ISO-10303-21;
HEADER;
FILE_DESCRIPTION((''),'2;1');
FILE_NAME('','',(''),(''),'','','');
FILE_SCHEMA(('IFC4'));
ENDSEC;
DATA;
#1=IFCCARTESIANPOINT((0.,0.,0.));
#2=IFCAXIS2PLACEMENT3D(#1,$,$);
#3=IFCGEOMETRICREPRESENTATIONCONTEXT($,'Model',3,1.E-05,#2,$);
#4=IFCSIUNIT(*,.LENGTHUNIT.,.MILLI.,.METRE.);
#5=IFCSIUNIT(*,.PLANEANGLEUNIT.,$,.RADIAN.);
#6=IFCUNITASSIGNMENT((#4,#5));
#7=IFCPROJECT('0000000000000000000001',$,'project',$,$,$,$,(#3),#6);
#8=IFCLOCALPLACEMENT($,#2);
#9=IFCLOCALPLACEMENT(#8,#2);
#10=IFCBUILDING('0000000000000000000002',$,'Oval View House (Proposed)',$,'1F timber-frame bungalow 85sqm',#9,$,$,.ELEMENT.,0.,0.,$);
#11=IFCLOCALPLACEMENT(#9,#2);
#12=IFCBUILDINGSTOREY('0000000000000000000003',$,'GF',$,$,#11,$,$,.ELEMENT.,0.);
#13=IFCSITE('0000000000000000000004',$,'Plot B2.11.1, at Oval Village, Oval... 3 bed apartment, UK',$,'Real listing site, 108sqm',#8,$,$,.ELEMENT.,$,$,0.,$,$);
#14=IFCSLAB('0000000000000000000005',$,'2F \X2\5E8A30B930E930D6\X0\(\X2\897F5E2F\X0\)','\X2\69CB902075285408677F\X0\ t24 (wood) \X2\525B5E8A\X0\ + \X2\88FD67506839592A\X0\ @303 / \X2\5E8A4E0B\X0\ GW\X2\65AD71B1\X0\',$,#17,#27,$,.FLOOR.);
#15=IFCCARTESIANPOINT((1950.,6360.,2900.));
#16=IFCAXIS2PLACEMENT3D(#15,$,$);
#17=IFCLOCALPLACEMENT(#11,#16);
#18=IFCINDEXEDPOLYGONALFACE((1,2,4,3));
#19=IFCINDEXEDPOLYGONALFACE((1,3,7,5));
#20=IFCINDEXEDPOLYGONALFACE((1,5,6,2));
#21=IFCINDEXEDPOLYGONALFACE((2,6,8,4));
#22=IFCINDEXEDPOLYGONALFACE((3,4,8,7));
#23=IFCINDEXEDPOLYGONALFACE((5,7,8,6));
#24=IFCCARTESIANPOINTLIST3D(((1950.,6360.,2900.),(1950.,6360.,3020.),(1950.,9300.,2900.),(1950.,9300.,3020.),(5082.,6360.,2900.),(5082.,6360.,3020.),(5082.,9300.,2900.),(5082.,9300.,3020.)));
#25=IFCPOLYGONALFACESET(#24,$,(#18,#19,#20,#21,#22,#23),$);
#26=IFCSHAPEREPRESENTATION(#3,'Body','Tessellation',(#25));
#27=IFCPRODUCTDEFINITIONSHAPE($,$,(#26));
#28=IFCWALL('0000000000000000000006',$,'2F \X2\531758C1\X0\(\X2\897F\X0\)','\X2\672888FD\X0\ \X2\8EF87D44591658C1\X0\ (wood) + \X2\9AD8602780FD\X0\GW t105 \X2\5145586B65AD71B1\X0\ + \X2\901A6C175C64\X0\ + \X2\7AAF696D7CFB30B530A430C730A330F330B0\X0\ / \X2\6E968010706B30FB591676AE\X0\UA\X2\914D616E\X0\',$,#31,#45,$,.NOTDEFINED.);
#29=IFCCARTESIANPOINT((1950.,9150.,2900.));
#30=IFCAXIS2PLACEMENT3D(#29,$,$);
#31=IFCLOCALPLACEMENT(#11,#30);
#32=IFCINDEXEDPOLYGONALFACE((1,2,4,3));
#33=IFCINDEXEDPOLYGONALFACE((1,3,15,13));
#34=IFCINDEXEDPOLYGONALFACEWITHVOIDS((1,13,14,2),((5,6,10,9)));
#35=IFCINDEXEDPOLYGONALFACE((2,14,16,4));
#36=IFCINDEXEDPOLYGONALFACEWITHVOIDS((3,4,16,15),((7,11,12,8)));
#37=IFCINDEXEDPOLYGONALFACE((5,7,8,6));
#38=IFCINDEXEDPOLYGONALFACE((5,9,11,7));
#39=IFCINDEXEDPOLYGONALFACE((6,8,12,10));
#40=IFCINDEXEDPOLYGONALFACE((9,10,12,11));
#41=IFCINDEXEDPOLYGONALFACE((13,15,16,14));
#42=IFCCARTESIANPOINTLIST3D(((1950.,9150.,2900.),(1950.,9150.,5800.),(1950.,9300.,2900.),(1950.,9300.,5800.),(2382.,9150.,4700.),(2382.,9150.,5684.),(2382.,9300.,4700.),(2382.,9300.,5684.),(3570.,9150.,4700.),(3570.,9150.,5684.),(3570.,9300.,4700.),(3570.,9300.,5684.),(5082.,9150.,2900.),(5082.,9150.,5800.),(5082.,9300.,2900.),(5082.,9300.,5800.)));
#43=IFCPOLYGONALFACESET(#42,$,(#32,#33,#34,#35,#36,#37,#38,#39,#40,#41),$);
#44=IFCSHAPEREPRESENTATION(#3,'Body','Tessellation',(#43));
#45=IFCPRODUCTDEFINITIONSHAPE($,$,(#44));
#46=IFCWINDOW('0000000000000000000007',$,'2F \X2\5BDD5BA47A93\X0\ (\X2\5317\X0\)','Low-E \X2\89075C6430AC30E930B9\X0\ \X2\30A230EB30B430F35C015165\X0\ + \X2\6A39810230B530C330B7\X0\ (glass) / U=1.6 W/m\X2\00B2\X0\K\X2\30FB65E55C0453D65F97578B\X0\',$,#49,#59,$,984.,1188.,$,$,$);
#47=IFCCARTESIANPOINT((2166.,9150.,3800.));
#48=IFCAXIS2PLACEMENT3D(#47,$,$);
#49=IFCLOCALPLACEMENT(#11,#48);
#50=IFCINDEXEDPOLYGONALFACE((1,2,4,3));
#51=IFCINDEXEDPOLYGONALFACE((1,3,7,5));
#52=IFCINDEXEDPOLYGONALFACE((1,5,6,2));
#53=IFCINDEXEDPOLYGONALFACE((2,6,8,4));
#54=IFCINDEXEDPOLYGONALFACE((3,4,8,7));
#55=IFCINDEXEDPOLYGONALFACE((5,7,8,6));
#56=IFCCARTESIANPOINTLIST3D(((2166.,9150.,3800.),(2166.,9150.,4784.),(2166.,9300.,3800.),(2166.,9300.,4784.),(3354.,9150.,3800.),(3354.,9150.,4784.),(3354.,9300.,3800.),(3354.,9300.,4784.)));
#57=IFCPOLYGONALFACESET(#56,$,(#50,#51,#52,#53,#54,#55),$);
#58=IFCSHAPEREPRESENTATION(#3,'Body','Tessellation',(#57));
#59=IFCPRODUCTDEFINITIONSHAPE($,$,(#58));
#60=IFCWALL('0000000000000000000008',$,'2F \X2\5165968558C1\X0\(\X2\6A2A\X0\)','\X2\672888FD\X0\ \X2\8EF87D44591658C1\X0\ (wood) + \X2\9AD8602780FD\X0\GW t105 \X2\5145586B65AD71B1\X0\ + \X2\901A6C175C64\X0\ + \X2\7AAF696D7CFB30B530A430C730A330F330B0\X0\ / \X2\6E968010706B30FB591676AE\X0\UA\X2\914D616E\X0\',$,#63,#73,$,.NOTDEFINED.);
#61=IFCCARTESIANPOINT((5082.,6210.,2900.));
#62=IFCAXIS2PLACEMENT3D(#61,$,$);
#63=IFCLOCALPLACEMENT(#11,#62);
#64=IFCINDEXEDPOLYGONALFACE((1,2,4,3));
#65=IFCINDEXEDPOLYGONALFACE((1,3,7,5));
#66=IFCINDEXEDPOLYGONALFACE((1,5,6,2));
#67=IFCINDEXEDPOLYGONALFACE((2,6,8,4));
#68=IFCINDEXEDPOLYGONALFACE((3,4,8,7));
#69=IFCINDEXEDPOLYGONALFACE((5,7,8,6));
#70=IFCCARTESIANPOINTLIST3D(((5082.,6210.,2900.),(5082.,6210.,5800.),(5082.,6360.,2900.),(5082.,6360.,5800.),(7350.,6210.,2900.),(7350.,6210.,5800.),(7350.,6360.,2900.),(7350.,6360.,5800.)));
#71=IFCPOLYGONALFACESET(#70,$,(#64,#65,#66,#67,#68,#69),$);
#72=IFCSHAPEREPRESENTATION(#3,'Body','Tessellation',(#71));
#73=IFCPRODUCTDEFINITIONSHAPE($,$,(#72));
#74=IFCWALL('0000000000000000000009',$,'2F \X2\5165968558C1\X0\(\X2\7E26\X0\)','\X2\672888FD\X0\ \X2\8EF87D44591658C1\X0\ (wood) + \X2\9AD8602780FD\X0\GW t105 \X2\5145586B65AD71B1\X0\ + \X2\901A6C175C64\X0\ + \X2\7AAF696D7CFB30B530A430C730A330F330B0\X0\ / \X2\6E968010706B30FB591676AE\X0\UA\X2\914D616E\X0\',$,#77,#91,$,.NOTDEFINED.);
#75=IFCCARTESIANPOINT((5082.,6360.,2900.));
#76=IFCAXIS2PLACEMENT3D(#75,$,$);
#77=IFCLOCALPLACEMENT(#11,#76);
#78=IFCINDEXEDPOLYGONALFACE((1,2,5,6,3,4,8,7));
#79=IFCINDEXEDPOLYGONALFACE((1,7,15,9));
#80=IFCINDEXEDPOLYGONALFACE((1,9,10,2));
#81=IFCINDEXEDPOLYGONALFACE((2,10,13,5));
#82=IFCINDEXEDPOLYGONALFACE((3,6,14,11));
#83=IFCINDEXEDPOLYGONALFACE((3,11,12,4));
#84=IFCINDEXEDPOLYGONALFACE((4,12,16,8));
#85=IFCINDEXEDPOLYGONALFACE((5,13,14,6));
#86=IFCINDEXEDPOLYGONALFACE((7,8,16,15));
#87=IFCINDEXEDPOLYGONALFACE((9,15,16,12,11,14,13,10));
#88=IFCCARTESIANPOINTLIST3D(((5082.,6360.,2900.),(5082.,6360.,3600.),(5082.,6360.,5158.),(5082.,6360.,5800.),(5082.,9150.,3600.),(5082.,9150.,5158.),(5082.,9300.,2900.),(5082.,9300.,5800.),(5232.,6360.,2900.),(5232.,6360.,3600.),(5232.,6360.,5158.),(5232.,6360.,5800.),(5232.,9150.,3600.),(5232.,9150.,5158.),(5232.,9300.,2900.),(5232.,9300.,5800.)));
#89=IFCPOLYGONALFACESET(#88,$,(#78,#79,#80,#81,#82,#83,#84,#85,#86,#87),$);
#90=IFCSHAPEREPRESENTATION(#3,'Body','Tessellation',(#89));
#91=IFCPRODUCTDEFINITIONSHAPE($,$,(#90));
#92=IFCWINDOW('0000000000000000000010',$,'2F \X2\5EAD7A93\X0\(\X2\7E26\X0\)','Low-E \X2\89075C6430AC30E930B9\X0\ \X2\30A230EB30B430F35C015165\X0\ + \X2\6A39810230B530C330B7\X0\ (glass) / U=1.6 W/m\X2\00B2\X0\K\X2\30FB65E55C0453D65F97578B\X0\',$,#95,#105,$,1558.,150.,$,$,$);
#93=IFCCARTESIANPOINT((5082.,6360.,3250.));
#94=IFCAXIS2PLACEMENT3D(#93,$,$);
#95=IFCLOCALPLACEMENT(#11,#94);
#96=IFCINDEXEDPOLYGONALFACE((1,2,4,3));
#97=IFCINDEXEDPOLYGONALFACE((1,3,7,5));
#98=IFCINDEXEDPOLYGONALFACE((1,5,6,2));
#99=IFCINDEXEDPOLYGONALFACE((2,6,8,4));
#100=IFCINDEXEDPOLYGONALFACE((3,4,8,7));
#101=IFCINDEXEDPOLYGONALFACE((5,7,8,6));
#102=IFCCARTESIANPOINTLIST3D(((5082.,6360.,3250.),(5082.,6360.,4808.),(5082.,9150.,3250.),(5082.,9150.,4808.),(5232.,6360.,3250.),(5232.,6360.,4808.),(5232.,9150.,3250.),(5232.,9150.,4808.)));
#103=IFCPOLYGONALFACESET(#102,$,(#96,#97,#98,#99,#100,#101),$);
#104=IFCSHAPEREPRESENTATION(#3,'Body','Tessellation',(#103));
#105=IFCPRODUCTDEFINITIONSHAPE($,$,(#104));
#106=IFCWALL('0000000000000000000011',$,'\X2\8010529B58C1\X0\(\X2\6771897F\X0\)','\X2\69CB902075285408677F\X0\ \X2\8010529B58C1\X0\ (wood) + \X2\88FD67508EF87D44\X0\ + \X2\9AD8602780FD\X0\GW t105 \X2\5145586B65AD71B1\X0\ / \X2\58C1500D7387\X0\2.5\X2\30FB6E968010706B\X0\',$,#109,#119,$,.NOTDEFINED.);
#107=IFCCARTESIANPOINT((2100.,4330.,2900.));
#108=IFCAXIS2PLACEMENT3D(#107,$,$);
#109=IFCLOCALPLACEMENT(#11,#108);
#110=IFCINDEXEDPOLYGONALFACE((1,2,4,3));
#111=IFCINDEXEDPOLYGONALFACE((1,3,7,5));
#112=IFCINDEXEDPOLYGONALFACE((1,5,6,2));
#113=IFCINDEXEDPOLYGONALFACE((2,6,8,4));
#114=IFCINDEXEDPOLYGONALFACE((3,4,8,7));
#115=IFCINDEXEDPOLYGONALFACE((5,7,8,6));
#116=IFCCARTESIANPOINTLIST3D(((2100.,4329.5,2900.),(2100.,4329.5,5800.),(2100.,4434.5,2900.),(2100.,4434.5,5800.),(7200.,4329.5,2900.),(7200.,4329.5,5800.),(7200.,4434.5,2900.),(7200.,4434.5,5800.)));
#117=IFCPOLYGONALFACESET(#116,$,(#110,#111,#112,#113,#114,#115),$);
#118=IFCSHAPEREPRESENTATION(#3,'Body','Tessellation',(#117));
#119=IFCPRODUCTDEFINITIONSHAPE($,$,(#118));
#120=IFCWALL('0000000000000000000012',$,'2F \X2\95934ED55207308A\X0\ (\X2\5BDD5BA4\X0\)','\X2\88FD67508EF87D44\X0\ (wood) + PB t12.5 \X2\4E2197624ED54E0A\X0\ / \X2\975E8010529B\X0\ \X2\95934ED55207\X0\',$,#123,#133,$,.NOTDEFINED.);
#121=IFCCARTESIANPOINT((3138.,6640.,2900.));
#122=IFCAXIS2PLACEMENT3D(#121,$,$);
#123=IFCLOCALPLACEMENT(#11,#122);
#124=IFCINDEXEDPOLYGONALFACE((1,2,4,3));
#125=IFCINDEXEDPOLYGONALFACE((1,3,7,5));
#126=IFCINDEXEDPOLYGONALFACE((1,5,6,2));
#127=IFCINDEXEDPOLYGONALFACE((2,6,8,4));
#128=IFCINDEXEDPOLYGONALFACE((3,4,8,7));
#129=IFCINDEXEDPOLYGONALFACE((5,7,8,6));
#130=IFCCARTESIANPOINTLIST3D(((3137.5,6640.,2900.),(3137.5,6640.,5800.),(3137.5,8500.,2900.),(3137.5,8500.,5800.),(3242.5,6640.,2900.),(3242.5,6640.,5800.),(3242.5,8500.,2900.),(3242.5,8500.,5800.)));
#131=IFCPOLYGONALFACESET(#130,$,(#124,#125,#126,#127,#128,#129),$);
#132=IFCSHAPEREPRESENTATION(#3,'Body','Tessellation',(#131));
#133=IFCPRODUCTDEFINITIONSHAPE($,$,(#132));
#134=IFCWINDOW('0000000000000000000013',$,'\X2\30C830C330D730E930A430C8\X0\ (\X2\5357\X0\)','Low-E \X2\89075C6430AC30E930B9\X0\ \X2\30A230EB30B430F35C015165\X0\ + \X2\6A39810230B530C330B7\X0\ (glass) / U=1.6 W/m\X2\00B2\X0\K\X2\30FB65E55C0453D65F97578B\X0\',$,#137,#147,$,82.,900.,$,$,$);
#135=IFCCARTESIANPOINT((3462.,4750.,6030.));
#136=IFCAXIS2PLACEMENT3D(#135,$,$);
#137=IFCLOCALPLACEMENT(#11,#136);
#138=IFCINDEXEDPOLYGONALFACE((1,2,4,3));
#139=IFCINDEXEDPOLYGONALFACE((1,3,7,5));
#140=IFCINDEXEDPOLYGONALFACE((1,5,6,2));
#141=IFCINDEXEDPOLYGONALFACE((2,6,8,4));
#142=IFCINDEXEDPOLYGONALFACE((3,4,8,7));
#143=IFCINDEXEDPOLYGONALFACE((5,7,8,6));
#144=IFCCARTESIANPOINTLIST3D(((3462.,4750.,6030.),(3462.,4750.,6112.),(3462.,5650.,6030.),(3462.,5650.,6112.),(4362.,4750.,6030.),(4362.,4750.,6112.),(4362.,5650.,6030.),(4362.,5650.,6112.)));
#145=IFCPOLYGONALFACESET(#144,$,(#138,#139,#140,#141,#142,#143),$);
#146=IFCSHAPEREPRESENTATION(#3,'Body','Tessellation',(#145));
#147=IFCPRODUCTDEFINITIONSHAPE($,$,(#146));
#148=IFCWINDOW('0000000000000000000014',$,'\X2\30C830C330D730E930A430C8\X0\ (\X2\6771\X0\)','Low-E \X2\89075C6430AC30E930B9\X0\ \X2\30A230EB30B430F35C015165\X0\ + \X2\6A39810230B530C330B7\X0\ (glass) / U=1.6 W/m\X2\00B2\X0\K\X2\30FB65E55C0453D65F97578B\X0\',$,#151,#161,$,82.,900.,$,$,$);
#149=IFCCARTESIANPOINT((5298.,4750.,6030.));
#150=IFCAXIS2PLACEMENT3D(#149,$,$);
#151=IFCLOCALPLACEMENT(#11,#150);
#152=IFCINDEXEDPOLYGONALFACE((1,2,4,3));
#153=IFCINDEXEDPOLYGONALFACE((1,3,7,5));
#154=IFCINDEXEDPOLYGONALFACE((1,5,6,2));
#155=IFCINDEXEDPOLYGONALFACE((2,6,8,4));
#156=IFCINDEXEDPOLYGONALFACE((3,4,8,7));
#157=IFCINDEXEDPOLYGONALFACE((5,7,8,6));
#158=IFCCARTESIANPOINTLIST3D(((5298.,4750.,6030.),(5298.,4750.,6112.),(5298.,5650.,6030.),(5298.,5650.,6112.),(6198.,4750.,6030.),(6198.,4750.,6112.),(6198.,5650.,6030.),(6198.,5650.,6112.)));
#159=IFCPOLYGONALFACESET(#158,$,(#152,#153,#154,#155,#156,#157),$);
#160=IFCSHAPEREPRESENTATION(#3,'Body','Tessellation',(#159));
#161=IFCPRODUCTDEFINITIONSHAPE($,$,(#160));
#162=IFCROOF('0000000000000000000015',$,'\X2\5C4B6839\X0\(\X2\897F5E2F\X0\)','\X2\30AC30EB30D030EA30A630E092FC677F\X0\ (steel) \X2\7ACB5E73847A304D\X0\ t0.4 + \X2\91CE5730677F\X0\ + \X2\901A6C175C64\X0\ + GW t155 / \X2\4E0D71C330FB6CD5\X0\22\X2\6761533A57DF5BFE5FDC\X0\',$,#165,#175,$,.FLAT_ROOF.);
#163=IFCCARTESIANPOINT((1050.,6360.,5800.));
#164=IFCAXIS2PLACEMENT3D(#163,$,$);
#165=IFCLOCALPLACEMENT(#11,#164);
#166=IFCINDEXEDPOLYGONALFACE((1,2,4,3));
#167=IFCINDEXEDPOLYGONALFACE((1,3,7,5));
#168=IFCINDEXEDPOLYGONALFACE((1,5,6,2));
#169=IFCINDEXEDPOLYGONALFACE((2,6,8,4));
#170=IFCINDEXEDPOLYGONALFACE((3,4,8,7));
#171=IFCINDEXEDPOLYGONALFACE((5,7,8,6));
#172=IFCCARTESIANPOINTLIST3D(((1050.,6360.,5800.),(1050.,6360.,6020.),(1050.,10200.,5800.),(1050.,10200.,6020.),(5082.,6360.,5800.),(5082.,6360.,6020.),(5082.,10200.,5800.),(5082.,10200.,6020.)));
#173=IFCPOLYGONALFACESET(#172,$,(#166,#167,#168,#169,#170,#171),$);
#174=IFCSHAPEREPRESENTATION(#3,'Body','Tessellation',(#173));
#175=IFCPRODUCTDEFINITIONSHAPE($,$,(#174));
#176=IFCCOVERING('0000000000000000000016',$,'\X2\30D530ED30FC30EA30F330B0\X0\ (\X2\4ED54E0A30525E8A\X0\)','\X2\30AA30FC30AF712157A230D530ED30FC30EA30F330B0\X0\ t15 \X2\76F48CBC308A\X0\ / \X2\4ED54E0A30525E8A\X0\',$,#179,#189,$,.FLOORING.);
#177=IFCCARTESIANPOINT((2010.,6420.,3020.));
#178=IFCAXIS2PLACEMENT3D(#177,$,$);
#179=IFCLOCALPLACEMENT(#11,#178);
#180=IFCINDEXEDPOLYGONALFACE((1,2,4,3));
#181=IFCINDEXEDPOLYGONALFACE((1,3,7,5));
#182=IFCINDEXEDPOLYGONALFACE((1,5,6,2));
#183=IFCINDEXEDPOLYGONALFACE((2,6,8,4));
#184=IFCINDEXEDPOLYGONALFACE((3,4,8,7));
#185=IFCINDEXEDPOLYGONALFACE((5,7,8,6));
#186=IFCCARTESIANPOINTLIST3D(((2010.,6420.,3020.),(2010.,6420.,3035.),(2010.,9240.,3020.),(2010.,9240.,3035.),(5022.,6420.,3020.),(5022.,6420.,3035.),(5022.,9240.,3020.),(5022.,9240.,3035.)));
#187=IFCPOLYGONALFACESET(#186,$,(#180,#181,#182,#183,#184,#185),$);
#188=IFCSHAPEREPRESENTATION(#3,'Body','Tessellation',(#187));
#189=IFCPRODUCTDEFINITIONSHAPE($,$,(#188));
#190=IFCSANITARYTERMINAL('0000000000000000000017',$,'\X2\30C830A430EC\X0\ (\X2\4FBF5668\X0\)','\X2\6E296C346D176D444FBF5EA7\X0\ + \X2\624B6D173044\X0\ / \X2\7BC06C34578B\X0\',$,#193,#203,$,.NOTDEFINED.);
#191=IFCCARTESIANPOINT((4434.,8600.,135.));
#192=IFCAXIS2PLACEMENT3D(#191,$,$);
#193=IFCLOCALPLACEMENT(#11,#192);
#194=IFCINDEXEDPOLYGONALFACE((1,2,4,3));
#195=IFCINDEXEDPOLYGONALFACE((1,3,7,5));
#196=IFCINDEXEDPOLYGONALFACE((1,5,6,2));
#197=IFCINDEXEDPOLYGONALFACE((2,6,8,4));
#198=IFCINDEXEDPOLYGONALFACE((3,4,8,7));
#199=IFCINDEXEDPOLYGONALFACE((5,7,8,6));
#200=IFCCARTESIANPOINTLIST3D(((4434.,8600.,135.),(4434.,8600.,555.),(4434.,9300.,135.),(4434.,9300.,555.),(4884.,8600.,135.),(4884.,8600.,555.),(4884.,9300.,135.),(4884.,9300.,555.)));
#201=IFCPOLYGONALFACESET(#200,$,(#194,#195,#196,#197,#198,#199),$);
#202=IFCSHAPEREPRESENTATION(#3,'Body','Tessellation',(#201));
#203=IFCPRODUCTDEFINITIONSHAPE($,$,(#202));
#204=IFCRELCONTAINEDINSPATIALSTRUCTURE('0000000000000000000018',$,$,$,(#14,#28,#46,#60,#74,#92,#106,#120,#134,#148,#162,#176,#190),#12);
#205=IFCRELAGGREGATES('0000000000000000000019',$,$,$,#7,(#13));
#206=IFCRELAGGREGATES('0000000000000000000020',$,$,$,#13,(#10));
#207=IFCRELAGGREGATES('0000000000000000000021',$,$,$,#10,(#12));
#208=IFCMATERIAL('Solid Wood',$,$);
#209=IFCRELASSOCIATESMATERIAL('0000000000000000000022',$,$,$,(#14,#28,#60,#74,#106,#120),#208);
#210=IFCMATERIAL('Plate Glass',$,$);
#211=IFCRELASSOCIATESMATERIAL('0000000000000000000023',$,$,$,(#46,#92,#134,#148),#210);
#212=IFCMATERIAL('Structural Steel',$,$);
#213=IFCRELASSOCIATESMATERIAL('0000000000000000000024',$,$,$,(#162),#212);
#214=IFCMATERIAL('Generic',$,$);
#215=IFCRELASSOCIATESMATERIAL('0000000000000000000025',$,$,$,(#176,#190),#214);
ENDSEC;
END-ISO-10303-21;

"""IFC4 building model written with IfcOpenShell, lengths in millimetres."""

from ifc_helpers import new_model, si_unit, frame, frame_2d, origin, place, context, project, spatial, rectangle, extrude, material, element, fill, save


model = new_model("IFC4")

# Units and contexts
model_context = context("Model", 3, precision=1e-05, world=origin())
ifc_project = project(units=[si_unit("LENGTHUNIT", "METRE", prefix="MILLI"), si_unit("PLANEANGLEUNIT", "RADIAN")], contexts=[model_context])

# Site, building, storey
site_placement = place(None, origin())
site = spatial("IfcSite", under=ifc_project, at=site_placement, Name="Plot B2.11.1, at Oval Village, Oval... 3 bed apartment, UK", ObjectType="Real listing site, 108sqm", CompositionType="ELEMENT", RefElevation=0.0)
building_placement = place(site_placement, origin())
building = spatial("IfcBuilding", under=site, at=building_placement, Name="Oval View House (Proposed)", ObjectType="1F timber-frame bungalow 85sqm", CompositionType="ELEMENT", ElevationOfRefHeight=0.0, ElevationOfTerrain=0.0)
storey_placement = place(building_placement, origin())
storey = spatial("IfcBuildingStorey", under=building, at=storey_placement, Name="GF", CompositionType="ELEMENT", Elevation=0.0)

# Slab
ifc_material_1 = material(Name="Solid Wood")
slab_placement = place(storey_placement, frame((1950.0, 6360.0, 2900.0)))
element("IfcSlab", 1, at=slab_placement, inside=storey, material=ifc_material_1, Name="2F 床スラブ(西帯)", Description="構造用合板 t24 (wood) 剛床 + 製材根太 @303 / 床下 GW断熱", PredefinedType="FLOOR", context=model_context, shape_type="SweptSolid", body=[
    extrude(rectangle(XDim=3132.0, YDim=2940.0, at=frame_2d((1566.0, 1470.0))), frame((1950.0, 6360.0, 2900.0)), (0.0, 0.0, 1.0), 120.0),
])

# Wall, opening, window
wall_1_placement = place(storey_placement, frame((1950.0, 9150.0, 2900.0)))
wall_1 = element("IfcWall", 2, at=wall_1_placement, inside=storey, material=ifc_material_1, Name="2F 北壁(西)", Description="木製 軸組外壁 (wood) + 高性能GW t105 充填断熱 + 通気層 + 窯業系サイディング / 準耐火・外皮UA配慮", PredefinedType="NOTDEFINED", context=model_context, shape_type="SweptSolid", body=[
    extrude(rectangle(XDim=3132.0, YDim=150.0, at=frame_2d((1566.0, 75.0))), frame((1950.0, 9150.0, 2900.0)), (0.0, 0.0, 1.0), 2900.0),
])
opening_1_placement = place(storey_placement, frame((2166.0, 9150.0, 3800.0)))
opening_1 = element("IfcOpeningElement", 3, at=opening_1_placement, cuts=wall_1, PredefinedType="NOTDEFINED", context=model_context, shape_type="SweptSolid", body=[
    extrude(rectangle(XDim=1188.0, YDim=150.0, at=frame_2d((594.0, 75.0))), frame((2166.0, 9150.0, 3800.0)), (0.0, 0.0, 1.0), 984.0),
])
ifc_material_2 = material(Name="Plate Glass")
window_1_placement = place(storey_placement, frame((2166.0, 9150.0, 3800.0)))
window_1 = element("IfcWindow", 4, at=window_1_placement, inside=storey, material=ifc_material_2, Name="2F 寝室窓 (北)", Description="Low-E 複層ガラス アルゴン封入 + 樹脂サッシ (glass) / U=1.6 W/m²K・日射取得型", OverallHeight=984.0, OverallWidth=1188.0, context=model_context, shape_type="SweptSolid", body=[
    extrude(rectangle(XDim=1188.0, YDim=150.0, at=frame_2d((594.0, 75.0))), frame((2166.0, 9150.0, 3800.0)), (0.0, 0.0, 1.0), 984.0),
])
fill(opening_1, window_1)

# Wall
wall_2_placement = place(storey_placement, frame((5082.0, 6210.0, 2900.0)))
element("IfcWall", 5, at=wall_2_placement, inside=storey, material=ifc_material_1, Name="2F 入隅壁(横)", Description="木製 軸組外壁 (wood) + 高性能GW t105 充填断熱 + 通気層 + 窯業系サイディング / 準耐火・外皮UA配慮", PredefinedType="NOTDEFINED", context=model_context, shape_type="SweptSolid", body=[
    extrude(rectangle(XDim=2268.0, YDim=150.0, at=frame_2d((1134.0, 75.0))), frame((5082.0, 6210.0, 2900.0)), (0.0, 0.0, 1.0), 2900.0),
])

# Wall, opening, window
wall_3_placement = place(storey_placement, frame((5082.0, 6360.0, 2900.0)))
wall_3 = element("IfcWall", 6, at=wall_3_placement, inside=storey, material=ifc_material_1, Name="2F 入隅壁(縦)", Description="木製 軸組外壁 (wood) + 高性能GW t105 充填断熱 + 通気層 + 窯業系サイディング / 準耐火・外皮UA配慮", PredefinedType="NOTDEFINED", context=model_context, shape_type="SweptSolid", body=[
    extrude(rectangle(XDim=150.0, YDim=2940.0, at=frame_2d((75.0, 1470.0))), frame((5082.0, 6360.0, 2900.0)), (0.0, 0.0, 1.0), 2900.0),
])
opening_2_placement = place(storey_placement, frame((5082.0, 6360.0, 3250.0)))
opening_2 = element("IfcOpeningElement", 7, at=opening_2_placement, cuts=wall_3, PredefinedType="NOTDEFINED", context=model_context, shape_type="SweptSolid", body=[
    extrude(rectangle(XDim=150.0, YDim=2790.0, at=frame_2d((75.0, 1395.0))), frame((5082.0, 6360.0, 3250.0)), (0.0, 0.0, 1.0), 1558.0),
])
window_2_placement = place(storey_placement, frame((5082.0, 6360.0, 3250.0)))
window_2 = element("IfcWindow", 8, at=window_2_placement, inside=storey, material=ifc_material_2, Name="2F 庭窓(縦)", Description="Low-E 複層ガラス アルゴン封入 + 樹脂サッシ (glass) / U=1.6 W/m²K・日射取得型", OverallHeight=1558.0, OverallWidth=150.0, context=model_context, shape_type="SweptSolid", body=[
    extrude(rectangle(XDim=150.0, YDim=2790.0, at=frame_2d((75.0, 1395.0))), frame((5082.0, 6360.0, 3250.0)), (0.0, 0.0, 1.0), 1558.0),
])
fill(opening_2, window_2)

# Walls
wall_4_placement = place(storey_placement, frame((2100.0, 4330.0, 2900.0)))
element("IfcWall", 9, at=wall_4_placement, inside=storey, material=ifc_material_1, Name="耐力壁(東西)", Description="構造用合板 耐力壁 (wood) + 製材軸組 + 高性能GW t105 充填断熱 / 壁倍率2.5・準耐火", PredefinedType="NOTDEFINED", context=model_context, shape_type="SweptSolid", body=[
    extrude(rectangle(XDim=5100.0, YDim=105.0, at=frame_2d((2550.0, 52.0))), frame((2100.0, 4330.0, 2900.0)), (0.0, 0.0, 1.0), 2900.0),
])
wall_5_placement = place(storey_placement, frame((3138.0, 6640.0, 2900.0)))
element("IfcWall", 10, at=wall_5_placement, inside=storey, material=ifc_material_1, Name="2F 間仕切り (寝室)", Description="製材軸組 (wood) + PB t12.5 両面仕上 / 非耐力 間仕切", PredefinedType="NOTDEFINED", context=model_context, shape_type="SweptSolid", body=[
    extrude(rectangle(XDim=105.0, YDim=1860.0, at=frame_2d((52.0, 930.0))), frame((3138.0, 6640.0, 2900.0)), (0.0, 0.0, 1.0), 2900.0),
])

# Windows
window_3_placement = place(storey_placement, frame((3462.0, 4750.0, 6030.0)))
element("IfcWindow", 11, at=window_3_placement, inside=storey, material=ifc_material_2, Name="トップライト (南)", Description="Low-E 複層ガラス アルゴン封入 + 樹脂サッシ (glass) / U=1.6 W/m²K・日射取得型", OverallHeight=82.0, OverallWidth=900.0, context=model_context, shape_type="SweptSolid", body=[
    extrude(rectangle(XDim=900.0, YDim=900.0, at=frame_2d((450.0, 450.0))), frame((3462.0, 4750.0, 6030.0)), (0.0, 0.0, 1.0), 82.0),
])
window_4_placement = place(storey_placement, frame((5298.0, 4750.0, 6030.0)))
element("IfcWindow", 12, at=window_4_placement, inside=storey, material=ifc_material_2, Name="トップライト (東)", Description="Low-E 複層ガラス アルゴン封入 + 樹脂サッシ (glass) / U=1.6 W/m²K・日射取得型", OverallHeight=82.0, OverallWidth=900.0, context=model_context, shape_type="SweptSolid", body=[
    extrude(rectangle(XDim=900.0, YDim=900.0, at=frame_2d((450.0, 450.0))), frame((5298.0, 4750.0, 6030.0)), (0.0, 0.0, 1.0), 82.0),
])

# Roof
ifc_material_3 = material(Name="Structural Steel")
for number, where, name in (
    (13, (1050.0, 6360.0, 5800.0), "屋根(西帯)"),
):
    element("IfcRoof", number, at=place(storey_placement, frame(where)), inside=storey, material=ifc_material_3, Name=name, Description="ガルバリウム鋼板 (steel) 立平葺き t0.4 + 野地板 + 通気層 + GW t155 / 不燃・法22条区域対応", PredefinedType="FLAT_ROOF", context=model_context, shape_type="SweptSolid", body=[
        extrude(rectangle(XDim=4032.0, YDim=3840.0, at=frame_2d((2016.0, 1920.0))), frame((1050.0, 6360.0, 5800.0)), (0.0, 0.0, 1.0), 220.0),
    ])

# Covering
ifc_material_4 = material(Name="Generic")
covering_placement = place(storey_placement, frame((2010.0, 6420.0, 3020.0)))
element("IfcCovering", 14, at=covering_placement, inside=storey, material=ifc_material_4, Name="フローリング (仕上げ床)", Description="オーク無垢フローリング t15 直貼り / 仕上げ床", PredefinedType="FLOORING", context=model_context, shape_type="SweptSolid", body=[
    extrude(rectangle(XDim=3012.0, YDim=2820.0, at=frame_2d((1506.0, 1410.0))), frame((2010.0, 6420.0, 3020.0)), (0.0, 0.0, 1.0), 15.0),
])

# Sanitary terminal
sanitary_terminal_placement = place(storey_placement, frame((4434.0, 8600.0, 135.0)))
element("IfcSanitaryTerminal", 15, at=sanitary_terminal_placement, inside=storey, material=ifc_material_4, Name="トイレ (便器)", Description="温水洗浄便座 + 手洗い / 節水型", PredefinedType="NOTDEFINED", context=model_context, shape_type="SweptSolid", body=[
    extrude(rectangle(XDim=450.0, YDim=700.0, at=frame_2d((225.0, 350.0))), frame((4434.0, 8600.0, 135.0)), (0.0, 0.0, 1.0), 420.0),
])

save(model, "model.ifc")
